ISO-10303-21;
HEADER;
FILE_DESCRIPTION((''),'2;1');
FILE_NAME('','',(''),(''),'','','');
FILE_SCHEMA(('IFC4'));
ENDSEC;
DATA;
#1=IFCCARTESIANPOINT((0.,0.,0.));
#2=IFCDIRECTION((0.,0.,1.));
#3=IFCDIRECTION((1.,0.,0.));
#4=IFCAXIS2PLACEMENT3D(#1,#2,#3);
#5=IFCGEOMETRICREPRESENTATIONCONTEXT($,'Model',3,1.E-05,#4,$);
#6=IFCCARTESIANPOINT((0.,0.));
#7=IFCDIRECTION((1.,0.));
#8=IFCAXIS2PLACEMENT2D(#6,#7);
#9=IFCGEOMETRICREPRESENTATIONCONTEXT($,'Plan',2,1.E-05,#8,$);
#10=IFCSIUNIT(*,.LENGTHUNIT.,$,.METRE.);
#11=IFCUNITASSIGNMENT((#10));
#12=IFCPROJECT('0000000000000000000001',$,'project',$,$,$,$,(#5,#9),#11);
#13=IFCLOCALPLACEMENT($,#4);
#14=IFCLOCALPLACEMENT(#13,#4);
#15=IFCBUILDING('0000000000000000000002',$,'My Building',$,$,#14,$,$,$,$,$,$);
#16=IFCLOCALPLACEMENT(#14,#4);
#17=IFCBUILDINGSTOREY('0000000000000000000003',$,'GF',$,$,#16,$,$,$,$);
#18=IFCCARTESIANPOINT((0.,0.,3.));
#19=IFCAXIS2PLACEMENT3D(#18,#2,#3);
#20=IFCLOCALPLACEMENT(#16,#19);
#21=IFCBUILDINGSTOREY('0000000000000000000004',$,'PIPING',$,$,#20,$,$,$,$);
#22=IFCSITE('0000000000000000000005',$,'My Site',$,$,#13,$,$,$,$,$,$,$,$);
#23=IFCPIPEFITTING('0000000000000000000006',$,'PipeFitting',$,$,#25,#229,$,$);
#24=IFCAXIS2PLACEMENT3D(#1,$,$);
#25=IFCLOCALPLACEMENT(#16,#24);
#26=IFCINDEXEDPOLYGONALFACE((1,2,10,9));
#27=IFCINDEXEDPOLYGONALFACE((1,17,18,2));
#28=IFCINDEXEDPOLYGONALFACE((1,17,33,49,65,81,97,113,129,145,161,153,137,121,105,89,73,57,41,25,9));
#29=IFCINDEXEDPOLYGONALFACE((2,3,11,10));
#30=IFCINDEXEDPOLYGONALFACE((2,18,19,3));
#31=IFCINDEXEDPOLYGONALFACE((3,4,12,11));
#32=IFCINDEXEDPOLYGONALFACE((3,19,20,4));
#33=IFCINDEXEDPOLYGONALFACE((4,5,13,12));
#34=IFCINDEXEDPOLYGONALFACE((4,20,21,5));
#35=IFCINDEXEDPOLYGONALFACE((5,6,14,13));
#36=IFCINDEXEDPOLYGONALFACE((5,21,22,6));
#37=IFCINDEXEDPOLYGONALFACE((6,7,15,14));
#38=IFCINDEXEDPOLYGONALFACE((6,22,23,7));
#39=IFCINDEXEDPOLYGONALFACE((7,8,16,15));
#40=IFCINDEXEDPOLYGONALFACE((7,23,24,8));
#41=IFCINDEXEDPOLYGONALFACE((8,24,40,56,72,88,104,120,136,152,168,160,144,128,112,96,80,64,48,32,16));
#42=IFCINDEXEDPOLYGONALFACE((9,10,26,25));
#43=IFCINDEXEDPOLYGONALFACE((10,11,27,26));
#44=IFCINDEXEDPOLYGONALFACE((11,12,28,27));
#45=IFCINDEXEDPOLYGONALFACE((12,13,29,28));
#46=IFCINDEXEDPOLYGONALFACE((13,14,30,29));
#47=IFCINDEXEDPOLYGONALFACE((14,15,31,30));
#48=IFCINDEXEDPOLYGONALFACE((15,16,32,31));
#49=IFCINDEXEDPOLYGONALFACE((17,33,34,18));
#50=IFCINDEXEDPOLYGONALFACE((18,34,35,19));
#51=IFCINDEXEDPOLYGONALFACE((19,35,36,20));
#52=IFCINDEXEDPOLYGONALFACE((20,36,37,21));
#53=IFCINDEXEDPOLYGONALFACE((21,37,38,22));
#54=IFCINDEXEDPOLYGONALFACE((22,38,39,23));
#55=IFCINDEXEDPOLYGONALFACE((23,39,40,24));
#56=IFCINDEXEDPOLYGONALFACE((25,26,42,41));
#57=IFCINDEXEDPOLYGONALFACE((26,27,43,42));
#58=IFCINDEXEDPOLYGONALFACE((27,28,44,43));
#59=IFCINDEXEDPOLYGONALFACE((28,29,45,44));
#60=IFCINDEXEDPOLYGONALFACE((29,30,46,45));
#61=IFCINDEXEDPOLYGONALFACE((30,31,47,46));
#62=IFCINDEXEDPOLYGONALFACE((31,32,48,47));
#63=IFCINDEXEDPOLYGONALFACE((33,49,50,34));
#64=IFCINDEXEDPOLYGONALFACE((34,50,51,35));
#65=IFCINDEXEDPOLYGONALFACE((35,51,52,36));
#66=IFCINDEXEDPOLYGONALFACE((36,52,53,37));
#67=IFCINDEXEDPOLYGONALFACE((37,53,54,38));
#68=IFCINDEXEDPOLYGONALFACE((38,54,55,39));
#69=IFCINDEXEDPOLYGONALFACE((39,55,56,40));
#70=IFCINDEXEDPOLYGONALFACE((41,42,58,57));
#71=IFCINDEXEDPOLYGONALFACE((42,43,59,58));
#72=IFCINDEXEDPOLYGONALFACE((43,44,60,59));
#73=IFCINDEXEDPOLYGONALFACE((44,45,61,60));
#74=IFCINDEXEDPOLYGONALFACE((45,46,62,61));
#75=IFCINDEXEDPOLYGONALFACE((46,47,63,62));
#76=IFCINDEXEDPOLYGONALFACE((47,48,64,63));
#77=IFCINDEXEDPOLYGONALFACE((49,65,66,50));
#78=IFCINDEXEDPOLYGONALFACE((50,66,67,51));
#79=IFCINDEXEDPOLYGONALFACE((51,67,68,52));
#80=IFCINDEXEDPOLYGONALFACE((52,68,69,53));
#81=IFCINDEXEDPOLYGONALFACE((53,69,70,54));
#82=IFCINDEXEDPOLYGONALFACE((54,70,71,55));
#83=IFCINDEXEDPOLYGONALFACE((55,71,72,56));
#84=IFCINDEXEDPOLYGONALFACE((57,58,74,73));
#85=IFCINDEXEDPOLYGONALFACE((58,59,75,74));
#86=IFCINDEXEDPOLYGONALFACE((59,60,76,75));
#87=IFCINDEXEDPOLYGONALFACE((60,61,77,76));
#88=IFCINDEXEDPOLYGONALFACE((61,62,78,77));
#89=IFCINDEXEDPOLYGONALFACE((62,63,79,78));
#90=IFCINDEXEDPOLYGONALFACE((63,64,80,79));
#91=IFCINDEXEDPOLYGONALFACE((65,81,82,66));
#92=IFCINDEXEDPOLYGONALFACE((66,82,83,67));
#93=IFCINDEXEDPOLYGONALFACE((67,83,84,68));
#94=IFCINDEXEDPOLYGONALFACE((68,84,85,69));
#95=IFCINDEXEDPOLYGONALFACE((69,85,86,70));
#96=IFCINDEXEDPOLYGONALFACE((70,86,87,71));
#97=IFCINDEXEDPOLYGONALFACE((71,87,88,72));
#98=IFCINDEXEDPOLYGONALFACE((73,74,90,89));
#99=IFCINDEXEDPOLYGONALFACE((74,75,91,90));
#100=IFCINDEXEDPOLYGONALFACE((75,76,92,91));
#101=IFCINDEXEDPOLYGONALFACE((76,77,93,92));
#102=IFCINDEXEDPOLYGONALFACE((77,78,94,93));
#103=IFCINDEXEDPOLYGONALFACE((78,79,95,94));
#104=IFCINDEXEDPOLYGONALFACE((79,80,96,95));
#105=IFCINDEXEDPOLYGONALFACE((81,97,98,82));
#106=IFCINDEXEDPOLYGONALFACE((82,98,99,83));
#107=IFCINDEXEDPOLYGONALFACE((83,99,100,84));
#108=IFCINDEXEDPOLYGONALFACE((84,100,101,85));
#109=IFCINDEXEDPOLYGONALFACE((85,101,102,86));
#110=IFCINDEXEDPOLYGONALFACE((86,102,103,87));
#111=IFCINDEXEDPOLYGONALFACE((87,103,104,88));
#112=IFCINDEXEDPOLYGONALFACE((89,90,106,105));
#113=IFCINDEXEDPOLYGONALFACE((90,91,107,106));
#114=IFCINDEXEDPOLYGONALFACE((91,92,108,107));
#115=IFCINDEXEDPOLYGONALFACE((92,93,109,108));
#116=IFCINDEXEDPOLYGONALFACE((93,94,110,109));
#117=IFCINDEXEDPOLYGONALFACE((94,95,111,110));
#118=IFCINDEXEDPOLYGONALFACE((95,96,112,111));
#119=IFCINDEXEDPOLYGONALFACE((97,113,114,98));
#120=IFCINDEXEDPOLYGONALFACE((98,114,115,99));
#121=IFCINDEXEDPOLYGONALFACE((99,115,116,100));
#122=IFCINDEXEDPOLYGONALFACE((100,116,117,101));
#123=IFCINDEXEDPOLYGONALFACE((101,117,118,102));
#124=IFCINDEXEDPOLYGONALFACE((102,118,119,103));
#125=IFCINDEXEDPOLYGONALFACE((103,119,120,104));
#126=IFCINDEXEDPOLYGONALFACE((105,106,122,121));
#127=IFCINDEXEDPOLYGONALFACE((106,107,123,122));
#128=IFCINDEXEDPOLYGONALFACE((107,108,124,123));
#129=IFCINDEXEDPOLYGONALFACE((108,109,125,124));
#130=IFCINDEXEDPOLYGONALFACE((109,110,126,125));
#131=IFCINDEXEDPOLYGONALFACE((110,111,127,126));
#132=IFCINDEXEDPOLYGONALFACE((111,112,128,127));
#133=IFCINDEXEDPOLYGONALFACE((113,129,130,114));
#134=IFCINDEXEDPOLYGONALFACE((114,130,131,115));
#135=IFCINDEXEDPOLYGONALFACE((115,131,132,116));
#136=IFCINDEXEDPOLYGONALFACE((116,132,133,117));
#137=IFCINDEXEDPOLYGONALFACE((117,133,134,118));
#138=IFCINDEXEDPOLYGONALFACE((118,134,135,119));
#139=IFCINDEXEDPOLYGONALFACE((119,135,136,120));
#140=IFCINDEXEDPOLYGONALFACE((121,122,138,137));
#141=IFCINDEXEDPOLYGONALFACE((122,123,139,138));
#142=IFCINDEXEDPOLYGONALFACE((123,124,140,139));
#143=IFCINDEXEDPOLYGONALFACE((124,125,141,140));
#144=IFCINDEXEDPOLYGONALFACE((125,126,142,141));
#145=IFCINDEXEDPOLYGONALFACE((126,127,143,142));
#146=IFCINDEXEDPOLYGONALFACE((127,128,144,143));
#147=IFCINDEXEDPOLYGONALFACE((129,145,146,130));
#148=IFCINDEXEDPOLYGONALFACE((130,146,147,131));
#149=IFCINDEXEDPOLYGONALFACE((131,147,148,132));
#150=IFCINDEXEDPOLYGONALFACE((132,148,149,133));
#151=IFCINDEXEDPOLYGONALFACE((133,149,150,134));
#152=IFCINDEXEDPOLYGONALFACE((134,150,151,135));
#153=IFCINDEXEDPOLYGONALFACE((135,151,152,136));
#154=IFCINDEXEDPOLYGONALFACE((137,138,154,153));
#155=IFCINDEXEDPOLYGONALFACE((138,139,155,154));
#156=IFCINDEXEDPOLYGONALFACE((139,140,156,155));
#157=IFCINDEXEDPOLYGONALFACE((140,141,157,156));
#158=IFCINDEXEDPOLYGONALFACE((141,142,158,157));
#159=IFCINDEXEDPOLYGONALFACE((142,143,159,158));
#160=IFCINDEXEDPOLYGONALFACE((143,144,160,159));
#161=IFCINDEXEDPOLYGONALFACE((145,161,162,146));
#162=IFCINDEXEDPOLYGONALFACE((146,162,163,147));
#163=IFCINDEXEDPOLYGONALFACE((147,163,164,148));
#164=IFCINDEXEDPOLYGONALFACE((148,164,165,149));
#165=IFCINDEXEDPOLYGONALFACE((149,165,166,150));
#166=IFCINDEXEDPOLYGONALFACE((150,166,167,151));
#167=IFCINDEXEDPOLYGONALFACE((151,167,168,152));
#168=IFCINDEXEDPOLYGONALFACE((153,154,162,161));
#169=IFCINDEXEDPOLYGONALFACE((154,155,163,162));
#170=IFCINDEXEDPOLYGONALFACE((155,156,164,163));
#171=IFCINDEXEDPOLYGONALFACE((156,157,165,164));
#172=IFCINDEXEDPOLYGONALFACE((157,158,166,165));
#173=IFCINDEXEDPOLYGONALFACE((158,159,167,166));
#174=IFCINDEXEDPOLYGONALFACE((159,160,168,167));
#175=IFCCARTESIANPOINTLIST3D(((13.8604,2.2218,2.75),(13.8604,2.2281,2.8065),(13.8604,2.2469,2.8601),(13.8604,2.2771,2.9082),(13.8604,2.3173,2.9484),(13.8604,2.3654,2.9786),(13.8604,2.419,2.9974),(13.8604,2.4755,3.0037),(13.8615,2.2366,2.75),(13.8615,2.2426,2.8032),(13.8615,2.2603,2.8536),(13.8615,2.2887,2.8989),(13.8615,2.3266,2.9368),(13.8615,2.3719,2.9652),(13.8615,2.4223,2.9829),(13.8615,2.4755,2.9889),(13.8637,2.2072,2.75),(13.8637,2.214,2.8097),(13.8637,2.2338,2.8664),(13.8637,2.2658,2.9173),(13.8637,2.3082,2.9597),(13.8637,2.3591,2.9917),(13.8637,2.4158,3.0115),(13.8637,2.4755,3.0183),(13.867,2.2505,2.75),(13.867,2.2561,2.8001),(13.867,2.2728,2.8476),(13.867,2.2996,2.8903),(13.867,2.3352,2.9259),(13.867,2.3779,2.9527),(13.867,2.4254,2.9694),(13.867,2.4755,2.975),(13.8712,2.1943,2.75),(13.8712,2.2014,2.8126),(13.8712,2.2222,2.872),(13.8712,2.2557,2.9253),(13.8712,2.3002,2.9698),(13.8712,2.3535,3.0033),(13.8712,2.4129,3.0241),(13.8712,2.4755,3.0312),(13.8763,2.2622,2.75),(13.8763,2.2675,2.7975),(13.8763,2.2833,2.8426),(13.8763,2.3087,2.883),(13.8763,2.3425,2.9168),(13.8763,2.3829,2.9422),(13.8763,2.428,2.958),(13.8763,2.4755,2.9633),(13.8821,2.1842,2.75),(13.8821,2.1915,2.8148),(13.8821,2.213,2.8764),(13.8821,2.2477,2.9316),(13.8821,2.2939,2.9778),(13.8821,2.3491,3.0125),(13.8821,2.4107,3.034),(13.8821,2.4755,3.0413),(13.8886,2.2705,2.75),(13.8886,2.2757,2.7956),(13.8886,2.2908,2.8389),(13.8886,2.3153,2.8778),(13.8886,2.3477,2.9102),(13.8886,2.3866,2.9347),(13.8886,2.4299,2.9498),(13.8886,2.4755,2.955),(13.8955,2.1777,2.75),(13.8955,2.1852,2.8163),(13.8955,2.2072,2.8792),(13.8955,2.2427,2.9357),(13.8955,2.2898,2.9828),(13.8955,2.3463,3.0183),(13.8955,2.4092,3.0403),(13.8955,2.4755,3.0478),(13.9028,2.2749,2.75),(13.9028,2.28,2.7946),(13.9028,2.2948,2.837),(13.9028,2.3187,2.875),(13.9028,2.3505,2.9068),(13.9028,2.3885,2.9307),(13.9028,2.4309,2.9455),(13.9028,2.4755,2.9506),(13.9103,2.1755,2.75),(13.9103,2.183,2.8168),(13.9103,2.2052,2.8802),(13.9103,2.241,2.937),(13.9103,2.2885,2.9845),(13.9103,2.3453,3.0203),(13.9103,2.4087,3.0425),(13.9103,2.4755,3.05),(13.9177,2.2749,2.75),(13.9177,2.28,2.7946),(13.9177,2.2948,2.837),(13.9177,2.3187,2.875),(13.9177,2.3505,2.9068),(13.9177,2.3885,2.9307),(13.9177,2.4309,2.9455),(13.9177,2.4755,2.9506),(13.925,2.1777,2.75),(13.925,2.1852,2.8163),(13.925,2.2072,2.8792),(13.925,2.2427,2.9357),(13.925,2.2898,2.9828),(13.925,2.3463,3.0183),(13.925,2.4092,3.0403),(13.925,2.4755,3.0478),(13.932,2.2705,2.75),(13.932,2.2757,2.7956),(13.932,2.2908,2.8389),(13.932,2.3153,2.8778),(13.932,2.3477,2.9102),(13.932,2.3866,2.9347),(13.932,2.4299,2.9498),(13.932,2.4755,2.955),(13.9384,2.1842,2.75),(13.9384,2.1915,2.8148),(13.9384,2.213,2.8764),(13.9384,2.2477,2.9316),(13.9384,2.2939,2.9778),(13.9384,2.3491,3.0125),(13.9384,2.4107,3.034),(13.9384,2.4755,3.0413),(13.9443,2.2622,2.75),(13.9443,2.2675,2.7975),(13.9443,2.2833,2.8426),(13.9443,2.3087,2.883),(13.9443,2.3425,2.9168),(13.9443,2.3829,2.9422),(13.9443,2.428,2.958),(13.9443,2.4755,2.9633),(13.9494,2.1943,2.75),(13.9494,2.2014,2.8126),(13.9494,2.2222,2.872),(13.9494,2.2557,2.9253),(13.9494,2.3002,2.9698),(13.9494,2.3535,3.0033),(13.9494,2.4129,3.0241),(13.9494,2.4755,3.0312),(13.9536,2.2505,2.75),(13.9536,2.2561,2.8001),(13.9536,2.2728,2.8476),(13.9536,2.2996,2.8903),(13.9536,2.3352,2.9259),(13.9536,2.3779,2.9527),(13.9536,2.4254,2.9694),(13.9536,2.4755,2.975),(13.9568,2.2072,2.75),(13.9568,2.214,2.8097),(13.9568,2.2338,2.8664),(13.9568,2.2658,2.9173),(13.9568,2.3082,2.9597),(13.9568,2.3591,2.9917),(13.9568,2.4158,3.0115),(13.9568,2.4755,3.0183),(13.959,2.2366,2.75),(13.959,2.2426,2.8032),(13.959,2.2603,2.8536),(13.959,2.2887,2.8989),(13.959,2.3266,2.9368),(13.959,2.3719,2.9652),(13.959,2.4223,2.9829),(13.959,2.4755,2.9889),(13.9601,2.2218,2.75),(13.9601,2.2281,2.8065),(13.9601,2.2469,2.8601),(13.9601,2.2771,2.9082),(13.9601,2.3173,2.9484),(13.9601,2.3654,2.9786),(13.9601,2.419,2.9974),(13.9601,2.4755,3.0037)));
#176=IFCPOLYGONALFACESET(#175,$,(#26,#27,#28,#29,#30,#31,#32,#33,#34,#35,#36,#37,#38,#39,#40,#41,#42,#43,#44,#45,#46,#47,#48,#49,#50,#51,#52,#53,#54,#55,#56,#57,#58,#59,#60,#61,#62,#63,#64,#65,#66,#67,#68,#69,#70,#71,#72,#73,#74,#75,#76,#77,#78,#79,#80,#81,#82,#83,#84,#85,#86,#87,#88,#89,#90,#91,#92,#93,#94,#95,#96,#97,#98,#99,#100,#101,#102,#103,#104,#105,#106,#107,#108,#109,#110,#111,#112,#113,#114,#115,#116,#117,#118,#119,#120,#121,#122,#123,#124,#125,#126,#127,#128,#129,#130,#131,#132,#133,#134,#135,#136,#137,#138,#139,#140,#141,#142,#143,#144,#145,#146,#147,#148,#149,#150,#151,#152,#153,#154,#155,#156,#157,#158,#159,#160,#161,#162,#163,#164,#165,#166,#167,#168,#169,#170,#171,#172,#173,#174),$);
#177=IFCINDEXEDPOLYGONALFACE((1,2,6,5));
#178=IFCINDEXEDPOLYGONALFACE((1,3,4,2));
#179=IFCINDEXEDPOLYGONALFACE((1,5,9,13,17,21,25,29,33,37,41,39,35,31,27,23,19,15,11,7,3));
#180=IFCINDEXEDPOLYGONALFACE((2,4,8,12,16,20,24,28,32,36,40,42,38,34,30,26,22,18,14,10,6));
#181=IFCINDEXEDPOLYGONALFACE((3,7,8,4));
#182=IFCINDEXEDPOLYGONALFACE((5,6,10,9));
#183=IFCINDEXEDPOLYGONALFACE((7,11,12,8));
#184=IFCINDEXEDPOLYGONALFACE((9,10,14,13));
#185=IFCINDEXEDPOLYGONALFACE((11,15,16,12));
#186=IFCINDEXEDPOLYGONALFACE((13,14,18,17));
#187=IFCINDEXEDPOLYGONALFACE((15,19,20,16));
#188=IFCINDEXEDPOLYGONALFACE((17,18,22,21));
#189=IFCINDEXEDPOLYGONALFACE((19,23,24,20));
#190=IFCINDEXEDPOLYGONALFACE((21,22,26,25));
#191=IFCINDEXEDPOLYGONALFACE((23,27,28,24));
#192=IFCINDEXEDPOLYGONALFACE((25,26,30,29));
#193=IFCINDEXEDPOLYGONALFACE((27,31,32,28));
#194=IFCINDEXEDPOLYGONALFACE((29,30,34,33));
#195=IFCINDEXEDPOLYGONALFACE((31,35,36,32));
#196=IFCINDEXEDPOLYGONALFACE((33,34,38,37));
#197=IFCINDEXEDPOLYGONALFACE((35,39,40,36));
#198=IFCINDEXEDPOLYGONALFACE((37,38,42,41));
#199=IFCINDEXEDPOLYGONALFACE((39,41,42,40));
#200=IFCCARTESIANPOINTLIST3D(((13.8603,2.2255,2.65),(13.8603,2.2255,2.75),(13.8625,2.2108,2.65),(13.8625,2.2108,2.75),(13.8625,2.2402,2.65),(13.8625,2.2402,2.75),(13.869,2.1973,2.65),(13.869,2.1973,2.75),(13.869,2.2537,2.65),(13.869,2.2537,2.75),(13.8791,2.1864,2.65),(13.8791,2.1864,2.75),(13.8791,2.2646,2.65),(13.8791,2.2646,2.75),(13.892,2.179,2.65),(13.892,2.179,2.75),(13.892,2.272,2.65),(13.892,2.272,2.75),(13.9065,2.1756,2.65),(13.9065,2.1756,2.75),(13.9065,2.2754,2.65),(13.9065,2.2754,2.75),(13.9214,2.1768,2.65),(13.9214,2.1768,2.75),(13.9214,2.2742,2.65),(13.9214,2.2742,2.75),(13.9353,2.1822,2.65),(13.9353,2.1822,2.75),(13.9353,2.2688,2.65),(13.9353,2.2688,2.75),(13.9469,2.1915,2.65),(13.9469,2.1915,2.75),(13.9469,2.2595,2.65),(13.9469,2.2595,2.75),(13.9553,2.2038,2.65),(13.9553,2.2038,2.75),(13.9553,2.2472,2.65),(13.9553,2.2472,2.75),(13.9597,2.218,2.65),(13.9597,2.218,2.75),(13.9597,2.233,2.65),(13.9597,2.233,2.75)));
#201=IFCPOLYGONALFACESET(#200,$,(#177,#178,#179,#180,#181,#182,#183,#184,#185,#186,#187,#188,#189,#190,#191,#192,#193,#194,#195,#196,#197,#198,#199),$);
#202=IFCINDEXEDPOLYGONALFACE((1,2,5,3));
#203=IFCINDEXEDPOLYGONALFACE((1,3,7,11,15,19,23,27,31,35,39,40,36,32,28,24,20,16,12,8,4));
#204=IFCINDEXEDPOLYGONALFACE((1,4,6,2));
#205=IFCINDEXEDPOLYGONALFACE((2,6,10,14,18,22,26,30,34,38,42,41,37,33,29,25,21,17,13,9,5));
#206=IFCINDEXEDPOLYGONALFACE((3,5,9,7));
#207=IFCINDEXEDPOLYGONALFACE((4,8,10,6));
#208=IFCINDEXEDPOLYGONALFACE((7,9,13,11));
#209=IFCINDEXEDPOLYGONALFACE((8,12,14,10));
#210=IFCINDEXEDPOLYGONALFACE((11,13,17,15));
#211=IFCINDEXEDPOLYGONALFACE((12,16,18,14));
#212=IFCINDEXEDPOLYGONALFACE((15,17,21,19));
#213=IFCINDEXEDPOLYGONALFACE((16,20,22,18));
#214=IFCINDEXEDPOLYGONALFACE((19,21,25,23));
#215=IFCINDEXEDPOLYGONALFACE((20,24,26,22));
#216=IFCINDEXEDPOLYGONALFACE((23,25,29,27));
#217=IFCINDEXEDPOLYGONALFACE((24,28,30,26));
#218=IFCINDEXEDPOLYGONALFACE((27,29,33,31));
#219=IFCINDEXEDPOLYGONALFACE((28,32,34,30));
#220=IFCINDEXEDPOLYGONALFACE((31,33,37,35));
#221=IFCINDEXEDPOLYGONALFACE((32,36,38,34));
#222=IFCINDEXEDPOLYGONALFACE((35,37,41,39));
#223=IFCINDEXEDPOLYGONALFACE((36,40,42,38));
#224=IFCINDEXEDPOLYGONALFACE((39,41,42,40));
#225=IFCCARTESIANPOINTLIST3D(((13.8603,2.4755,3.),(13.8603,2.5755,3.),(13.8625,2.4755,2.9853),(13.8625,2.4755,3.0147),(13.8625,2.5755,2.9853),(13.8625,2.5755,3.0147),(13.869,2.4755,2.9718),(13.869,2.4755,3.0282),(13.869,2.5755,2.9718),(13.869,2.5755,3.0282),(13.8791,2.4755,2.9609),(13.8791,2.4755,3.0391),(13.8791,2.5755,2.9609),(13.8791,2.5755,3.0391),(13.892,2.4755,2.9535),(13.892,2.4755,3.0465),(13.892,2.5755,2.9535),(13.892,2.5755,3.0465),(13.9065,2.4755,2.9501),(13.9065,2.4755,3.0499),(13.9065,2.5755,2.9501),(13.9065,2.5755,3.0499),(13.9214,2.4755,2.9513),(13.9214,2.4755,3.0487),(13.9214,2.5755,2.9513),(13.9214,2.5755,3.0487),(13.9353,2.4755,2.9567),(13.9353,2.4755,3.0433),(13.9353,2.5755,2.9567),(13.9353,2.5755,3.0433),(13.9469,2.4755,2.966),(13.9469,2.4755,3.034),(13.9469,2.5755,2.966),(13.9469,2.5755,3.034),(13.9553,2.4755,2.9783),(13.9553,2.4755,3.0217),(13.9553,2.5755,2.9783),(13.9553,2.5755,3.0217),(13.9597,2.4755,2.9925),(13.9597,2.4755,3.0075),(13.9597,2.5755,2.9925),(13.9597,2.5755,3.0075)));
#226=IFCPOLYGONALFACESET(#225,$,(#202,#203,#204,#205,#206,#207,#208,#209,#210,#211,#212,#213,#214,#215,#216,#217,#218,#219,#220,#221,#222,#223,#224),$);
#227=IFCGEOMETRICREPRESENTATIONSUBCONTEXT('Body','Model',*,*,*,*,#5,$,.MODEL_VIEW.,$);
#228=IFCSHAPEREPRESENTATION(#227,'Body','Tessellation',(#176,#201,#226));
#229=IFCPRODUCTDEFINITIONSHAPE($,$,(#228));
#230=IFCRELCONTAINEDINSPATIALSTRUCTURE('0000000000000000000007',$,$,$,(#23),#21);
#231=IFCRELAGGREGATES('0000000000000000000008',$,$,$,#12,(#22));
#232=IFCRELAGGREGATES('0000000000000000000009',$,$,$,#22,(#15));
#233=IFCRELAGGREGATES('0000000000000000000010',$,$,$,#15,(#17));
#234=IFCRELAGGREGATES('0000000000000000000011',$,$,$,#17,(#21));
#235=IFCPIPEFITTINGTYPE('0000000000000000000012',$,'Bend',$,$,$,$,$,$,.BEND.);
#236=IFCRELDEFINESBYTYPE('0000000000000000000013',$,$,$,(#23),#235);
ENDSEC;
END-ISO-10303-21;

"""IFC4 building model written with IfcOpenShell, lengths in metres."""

from ifc_helpers import new_model, entity, si_unit, frame, origin_with_axes, origin_2d_with_axis, place, context, subcontext, project, spatial, circle, extrude, source, transform, mapped, type_object, type_shapes, element, save


model = new_model("IFC4")

# Units and contexts
model_context = context("Model", 3, precision=1e-05, world=origin_with_axes())
plan_context = context("Plan", 2, precision=1e-05, world=origin_2d_with_axis())
body_context = subcontext(model_context, "Body", "Model", "MODEL_VIEW")
ifc_project = project(units=[si_unit("LENGTHUNIT", "METRE")], contexts=[model_context, plan_context])

# Site, building, storeys
site_placement = place(None, origin_with_axes())
site = spatial("IfcSite", under=ifc_project, at=site_placement, Name="My Site")
building_placement = place(site_placement, origin_with_axes())
building = spatial("IfcBuilding", under=site, at=building_placement, Name="My Building")
storey_1_placement = place(building_placement, origin_with_axes())
storey_1 = spatial("IfcBuildingStorey", under=building, at=storey_1_placement, Name="GF")
storey_2_placement = place(storey_1_placement, frame((0.0, 0.0, 3.0), z_axis=(0.0, 0.0, 1.0), x_axis=(1.0, 0.0, 0.0)))
storey_2 = spatial("IfcBuildingStorey", under=storey_1, at=storey_2_placement, Name="PIPING")

# Pipe fitting
pipe_fitting_type = type_object("IfcPipeFittingType", Name="Bend", PredefinedType="BEND")
shared_shape = source(origin_with_axes(), body_context, "Body", "SolidModel", [
    entity("IfcSweptDiskSolid", entity("IfcIndexedPolyCurve", entity("IfcCartesianPointList3D", [[0.0, 0.0, -0.1], [0.0, 0.0732, -0.2768], [0.0, 0.25, -0.35]]), [entity("IfcArcIndex", [1, 2, 3])]), 0.05),
    extrude(circle(Radius=0.05), origin_with_axes(), (0.0, 0.0, -1.0), 0.1),
    extrude(circle(Radius=0.05), frame((0.0, 0.25, -0.35), z_axis=(0.0, 1.0, 0.0), x_axis=(1.0, 0.0, 0.0)), (0.0, 0.0, 1.0), 0.1),
])
type_shapes(pipe_fitting_type, [shared_shape])
for number, where, z_axis, x_axis, name in (
    (1, (13.9103, 2.2255, -0.35), (0.0, 0.0, -1.0), (-1.0, 0.0, 0.0), "PipeFitting"),
):
    element("IfcPipeFitting", number, at=place(storey_2_placement, frame(where, z_axis=z_axis, x_axis=x_axis)), inside=storey_2, type_object=pipe_fitting_type, Name=name, context=body_context, shape_type="MappedRepresentation", body=[
        mapped(shared_shape, transform((0.0, 0.0, 0.0), x_axis=(1.0, 0.0, 0.0), y_axis=(0.0, 1.0, 0.0), z_axis=(0.0, 0.0, 1.0), scale=1.0)),
    ])

save(model, "model.ifc")
